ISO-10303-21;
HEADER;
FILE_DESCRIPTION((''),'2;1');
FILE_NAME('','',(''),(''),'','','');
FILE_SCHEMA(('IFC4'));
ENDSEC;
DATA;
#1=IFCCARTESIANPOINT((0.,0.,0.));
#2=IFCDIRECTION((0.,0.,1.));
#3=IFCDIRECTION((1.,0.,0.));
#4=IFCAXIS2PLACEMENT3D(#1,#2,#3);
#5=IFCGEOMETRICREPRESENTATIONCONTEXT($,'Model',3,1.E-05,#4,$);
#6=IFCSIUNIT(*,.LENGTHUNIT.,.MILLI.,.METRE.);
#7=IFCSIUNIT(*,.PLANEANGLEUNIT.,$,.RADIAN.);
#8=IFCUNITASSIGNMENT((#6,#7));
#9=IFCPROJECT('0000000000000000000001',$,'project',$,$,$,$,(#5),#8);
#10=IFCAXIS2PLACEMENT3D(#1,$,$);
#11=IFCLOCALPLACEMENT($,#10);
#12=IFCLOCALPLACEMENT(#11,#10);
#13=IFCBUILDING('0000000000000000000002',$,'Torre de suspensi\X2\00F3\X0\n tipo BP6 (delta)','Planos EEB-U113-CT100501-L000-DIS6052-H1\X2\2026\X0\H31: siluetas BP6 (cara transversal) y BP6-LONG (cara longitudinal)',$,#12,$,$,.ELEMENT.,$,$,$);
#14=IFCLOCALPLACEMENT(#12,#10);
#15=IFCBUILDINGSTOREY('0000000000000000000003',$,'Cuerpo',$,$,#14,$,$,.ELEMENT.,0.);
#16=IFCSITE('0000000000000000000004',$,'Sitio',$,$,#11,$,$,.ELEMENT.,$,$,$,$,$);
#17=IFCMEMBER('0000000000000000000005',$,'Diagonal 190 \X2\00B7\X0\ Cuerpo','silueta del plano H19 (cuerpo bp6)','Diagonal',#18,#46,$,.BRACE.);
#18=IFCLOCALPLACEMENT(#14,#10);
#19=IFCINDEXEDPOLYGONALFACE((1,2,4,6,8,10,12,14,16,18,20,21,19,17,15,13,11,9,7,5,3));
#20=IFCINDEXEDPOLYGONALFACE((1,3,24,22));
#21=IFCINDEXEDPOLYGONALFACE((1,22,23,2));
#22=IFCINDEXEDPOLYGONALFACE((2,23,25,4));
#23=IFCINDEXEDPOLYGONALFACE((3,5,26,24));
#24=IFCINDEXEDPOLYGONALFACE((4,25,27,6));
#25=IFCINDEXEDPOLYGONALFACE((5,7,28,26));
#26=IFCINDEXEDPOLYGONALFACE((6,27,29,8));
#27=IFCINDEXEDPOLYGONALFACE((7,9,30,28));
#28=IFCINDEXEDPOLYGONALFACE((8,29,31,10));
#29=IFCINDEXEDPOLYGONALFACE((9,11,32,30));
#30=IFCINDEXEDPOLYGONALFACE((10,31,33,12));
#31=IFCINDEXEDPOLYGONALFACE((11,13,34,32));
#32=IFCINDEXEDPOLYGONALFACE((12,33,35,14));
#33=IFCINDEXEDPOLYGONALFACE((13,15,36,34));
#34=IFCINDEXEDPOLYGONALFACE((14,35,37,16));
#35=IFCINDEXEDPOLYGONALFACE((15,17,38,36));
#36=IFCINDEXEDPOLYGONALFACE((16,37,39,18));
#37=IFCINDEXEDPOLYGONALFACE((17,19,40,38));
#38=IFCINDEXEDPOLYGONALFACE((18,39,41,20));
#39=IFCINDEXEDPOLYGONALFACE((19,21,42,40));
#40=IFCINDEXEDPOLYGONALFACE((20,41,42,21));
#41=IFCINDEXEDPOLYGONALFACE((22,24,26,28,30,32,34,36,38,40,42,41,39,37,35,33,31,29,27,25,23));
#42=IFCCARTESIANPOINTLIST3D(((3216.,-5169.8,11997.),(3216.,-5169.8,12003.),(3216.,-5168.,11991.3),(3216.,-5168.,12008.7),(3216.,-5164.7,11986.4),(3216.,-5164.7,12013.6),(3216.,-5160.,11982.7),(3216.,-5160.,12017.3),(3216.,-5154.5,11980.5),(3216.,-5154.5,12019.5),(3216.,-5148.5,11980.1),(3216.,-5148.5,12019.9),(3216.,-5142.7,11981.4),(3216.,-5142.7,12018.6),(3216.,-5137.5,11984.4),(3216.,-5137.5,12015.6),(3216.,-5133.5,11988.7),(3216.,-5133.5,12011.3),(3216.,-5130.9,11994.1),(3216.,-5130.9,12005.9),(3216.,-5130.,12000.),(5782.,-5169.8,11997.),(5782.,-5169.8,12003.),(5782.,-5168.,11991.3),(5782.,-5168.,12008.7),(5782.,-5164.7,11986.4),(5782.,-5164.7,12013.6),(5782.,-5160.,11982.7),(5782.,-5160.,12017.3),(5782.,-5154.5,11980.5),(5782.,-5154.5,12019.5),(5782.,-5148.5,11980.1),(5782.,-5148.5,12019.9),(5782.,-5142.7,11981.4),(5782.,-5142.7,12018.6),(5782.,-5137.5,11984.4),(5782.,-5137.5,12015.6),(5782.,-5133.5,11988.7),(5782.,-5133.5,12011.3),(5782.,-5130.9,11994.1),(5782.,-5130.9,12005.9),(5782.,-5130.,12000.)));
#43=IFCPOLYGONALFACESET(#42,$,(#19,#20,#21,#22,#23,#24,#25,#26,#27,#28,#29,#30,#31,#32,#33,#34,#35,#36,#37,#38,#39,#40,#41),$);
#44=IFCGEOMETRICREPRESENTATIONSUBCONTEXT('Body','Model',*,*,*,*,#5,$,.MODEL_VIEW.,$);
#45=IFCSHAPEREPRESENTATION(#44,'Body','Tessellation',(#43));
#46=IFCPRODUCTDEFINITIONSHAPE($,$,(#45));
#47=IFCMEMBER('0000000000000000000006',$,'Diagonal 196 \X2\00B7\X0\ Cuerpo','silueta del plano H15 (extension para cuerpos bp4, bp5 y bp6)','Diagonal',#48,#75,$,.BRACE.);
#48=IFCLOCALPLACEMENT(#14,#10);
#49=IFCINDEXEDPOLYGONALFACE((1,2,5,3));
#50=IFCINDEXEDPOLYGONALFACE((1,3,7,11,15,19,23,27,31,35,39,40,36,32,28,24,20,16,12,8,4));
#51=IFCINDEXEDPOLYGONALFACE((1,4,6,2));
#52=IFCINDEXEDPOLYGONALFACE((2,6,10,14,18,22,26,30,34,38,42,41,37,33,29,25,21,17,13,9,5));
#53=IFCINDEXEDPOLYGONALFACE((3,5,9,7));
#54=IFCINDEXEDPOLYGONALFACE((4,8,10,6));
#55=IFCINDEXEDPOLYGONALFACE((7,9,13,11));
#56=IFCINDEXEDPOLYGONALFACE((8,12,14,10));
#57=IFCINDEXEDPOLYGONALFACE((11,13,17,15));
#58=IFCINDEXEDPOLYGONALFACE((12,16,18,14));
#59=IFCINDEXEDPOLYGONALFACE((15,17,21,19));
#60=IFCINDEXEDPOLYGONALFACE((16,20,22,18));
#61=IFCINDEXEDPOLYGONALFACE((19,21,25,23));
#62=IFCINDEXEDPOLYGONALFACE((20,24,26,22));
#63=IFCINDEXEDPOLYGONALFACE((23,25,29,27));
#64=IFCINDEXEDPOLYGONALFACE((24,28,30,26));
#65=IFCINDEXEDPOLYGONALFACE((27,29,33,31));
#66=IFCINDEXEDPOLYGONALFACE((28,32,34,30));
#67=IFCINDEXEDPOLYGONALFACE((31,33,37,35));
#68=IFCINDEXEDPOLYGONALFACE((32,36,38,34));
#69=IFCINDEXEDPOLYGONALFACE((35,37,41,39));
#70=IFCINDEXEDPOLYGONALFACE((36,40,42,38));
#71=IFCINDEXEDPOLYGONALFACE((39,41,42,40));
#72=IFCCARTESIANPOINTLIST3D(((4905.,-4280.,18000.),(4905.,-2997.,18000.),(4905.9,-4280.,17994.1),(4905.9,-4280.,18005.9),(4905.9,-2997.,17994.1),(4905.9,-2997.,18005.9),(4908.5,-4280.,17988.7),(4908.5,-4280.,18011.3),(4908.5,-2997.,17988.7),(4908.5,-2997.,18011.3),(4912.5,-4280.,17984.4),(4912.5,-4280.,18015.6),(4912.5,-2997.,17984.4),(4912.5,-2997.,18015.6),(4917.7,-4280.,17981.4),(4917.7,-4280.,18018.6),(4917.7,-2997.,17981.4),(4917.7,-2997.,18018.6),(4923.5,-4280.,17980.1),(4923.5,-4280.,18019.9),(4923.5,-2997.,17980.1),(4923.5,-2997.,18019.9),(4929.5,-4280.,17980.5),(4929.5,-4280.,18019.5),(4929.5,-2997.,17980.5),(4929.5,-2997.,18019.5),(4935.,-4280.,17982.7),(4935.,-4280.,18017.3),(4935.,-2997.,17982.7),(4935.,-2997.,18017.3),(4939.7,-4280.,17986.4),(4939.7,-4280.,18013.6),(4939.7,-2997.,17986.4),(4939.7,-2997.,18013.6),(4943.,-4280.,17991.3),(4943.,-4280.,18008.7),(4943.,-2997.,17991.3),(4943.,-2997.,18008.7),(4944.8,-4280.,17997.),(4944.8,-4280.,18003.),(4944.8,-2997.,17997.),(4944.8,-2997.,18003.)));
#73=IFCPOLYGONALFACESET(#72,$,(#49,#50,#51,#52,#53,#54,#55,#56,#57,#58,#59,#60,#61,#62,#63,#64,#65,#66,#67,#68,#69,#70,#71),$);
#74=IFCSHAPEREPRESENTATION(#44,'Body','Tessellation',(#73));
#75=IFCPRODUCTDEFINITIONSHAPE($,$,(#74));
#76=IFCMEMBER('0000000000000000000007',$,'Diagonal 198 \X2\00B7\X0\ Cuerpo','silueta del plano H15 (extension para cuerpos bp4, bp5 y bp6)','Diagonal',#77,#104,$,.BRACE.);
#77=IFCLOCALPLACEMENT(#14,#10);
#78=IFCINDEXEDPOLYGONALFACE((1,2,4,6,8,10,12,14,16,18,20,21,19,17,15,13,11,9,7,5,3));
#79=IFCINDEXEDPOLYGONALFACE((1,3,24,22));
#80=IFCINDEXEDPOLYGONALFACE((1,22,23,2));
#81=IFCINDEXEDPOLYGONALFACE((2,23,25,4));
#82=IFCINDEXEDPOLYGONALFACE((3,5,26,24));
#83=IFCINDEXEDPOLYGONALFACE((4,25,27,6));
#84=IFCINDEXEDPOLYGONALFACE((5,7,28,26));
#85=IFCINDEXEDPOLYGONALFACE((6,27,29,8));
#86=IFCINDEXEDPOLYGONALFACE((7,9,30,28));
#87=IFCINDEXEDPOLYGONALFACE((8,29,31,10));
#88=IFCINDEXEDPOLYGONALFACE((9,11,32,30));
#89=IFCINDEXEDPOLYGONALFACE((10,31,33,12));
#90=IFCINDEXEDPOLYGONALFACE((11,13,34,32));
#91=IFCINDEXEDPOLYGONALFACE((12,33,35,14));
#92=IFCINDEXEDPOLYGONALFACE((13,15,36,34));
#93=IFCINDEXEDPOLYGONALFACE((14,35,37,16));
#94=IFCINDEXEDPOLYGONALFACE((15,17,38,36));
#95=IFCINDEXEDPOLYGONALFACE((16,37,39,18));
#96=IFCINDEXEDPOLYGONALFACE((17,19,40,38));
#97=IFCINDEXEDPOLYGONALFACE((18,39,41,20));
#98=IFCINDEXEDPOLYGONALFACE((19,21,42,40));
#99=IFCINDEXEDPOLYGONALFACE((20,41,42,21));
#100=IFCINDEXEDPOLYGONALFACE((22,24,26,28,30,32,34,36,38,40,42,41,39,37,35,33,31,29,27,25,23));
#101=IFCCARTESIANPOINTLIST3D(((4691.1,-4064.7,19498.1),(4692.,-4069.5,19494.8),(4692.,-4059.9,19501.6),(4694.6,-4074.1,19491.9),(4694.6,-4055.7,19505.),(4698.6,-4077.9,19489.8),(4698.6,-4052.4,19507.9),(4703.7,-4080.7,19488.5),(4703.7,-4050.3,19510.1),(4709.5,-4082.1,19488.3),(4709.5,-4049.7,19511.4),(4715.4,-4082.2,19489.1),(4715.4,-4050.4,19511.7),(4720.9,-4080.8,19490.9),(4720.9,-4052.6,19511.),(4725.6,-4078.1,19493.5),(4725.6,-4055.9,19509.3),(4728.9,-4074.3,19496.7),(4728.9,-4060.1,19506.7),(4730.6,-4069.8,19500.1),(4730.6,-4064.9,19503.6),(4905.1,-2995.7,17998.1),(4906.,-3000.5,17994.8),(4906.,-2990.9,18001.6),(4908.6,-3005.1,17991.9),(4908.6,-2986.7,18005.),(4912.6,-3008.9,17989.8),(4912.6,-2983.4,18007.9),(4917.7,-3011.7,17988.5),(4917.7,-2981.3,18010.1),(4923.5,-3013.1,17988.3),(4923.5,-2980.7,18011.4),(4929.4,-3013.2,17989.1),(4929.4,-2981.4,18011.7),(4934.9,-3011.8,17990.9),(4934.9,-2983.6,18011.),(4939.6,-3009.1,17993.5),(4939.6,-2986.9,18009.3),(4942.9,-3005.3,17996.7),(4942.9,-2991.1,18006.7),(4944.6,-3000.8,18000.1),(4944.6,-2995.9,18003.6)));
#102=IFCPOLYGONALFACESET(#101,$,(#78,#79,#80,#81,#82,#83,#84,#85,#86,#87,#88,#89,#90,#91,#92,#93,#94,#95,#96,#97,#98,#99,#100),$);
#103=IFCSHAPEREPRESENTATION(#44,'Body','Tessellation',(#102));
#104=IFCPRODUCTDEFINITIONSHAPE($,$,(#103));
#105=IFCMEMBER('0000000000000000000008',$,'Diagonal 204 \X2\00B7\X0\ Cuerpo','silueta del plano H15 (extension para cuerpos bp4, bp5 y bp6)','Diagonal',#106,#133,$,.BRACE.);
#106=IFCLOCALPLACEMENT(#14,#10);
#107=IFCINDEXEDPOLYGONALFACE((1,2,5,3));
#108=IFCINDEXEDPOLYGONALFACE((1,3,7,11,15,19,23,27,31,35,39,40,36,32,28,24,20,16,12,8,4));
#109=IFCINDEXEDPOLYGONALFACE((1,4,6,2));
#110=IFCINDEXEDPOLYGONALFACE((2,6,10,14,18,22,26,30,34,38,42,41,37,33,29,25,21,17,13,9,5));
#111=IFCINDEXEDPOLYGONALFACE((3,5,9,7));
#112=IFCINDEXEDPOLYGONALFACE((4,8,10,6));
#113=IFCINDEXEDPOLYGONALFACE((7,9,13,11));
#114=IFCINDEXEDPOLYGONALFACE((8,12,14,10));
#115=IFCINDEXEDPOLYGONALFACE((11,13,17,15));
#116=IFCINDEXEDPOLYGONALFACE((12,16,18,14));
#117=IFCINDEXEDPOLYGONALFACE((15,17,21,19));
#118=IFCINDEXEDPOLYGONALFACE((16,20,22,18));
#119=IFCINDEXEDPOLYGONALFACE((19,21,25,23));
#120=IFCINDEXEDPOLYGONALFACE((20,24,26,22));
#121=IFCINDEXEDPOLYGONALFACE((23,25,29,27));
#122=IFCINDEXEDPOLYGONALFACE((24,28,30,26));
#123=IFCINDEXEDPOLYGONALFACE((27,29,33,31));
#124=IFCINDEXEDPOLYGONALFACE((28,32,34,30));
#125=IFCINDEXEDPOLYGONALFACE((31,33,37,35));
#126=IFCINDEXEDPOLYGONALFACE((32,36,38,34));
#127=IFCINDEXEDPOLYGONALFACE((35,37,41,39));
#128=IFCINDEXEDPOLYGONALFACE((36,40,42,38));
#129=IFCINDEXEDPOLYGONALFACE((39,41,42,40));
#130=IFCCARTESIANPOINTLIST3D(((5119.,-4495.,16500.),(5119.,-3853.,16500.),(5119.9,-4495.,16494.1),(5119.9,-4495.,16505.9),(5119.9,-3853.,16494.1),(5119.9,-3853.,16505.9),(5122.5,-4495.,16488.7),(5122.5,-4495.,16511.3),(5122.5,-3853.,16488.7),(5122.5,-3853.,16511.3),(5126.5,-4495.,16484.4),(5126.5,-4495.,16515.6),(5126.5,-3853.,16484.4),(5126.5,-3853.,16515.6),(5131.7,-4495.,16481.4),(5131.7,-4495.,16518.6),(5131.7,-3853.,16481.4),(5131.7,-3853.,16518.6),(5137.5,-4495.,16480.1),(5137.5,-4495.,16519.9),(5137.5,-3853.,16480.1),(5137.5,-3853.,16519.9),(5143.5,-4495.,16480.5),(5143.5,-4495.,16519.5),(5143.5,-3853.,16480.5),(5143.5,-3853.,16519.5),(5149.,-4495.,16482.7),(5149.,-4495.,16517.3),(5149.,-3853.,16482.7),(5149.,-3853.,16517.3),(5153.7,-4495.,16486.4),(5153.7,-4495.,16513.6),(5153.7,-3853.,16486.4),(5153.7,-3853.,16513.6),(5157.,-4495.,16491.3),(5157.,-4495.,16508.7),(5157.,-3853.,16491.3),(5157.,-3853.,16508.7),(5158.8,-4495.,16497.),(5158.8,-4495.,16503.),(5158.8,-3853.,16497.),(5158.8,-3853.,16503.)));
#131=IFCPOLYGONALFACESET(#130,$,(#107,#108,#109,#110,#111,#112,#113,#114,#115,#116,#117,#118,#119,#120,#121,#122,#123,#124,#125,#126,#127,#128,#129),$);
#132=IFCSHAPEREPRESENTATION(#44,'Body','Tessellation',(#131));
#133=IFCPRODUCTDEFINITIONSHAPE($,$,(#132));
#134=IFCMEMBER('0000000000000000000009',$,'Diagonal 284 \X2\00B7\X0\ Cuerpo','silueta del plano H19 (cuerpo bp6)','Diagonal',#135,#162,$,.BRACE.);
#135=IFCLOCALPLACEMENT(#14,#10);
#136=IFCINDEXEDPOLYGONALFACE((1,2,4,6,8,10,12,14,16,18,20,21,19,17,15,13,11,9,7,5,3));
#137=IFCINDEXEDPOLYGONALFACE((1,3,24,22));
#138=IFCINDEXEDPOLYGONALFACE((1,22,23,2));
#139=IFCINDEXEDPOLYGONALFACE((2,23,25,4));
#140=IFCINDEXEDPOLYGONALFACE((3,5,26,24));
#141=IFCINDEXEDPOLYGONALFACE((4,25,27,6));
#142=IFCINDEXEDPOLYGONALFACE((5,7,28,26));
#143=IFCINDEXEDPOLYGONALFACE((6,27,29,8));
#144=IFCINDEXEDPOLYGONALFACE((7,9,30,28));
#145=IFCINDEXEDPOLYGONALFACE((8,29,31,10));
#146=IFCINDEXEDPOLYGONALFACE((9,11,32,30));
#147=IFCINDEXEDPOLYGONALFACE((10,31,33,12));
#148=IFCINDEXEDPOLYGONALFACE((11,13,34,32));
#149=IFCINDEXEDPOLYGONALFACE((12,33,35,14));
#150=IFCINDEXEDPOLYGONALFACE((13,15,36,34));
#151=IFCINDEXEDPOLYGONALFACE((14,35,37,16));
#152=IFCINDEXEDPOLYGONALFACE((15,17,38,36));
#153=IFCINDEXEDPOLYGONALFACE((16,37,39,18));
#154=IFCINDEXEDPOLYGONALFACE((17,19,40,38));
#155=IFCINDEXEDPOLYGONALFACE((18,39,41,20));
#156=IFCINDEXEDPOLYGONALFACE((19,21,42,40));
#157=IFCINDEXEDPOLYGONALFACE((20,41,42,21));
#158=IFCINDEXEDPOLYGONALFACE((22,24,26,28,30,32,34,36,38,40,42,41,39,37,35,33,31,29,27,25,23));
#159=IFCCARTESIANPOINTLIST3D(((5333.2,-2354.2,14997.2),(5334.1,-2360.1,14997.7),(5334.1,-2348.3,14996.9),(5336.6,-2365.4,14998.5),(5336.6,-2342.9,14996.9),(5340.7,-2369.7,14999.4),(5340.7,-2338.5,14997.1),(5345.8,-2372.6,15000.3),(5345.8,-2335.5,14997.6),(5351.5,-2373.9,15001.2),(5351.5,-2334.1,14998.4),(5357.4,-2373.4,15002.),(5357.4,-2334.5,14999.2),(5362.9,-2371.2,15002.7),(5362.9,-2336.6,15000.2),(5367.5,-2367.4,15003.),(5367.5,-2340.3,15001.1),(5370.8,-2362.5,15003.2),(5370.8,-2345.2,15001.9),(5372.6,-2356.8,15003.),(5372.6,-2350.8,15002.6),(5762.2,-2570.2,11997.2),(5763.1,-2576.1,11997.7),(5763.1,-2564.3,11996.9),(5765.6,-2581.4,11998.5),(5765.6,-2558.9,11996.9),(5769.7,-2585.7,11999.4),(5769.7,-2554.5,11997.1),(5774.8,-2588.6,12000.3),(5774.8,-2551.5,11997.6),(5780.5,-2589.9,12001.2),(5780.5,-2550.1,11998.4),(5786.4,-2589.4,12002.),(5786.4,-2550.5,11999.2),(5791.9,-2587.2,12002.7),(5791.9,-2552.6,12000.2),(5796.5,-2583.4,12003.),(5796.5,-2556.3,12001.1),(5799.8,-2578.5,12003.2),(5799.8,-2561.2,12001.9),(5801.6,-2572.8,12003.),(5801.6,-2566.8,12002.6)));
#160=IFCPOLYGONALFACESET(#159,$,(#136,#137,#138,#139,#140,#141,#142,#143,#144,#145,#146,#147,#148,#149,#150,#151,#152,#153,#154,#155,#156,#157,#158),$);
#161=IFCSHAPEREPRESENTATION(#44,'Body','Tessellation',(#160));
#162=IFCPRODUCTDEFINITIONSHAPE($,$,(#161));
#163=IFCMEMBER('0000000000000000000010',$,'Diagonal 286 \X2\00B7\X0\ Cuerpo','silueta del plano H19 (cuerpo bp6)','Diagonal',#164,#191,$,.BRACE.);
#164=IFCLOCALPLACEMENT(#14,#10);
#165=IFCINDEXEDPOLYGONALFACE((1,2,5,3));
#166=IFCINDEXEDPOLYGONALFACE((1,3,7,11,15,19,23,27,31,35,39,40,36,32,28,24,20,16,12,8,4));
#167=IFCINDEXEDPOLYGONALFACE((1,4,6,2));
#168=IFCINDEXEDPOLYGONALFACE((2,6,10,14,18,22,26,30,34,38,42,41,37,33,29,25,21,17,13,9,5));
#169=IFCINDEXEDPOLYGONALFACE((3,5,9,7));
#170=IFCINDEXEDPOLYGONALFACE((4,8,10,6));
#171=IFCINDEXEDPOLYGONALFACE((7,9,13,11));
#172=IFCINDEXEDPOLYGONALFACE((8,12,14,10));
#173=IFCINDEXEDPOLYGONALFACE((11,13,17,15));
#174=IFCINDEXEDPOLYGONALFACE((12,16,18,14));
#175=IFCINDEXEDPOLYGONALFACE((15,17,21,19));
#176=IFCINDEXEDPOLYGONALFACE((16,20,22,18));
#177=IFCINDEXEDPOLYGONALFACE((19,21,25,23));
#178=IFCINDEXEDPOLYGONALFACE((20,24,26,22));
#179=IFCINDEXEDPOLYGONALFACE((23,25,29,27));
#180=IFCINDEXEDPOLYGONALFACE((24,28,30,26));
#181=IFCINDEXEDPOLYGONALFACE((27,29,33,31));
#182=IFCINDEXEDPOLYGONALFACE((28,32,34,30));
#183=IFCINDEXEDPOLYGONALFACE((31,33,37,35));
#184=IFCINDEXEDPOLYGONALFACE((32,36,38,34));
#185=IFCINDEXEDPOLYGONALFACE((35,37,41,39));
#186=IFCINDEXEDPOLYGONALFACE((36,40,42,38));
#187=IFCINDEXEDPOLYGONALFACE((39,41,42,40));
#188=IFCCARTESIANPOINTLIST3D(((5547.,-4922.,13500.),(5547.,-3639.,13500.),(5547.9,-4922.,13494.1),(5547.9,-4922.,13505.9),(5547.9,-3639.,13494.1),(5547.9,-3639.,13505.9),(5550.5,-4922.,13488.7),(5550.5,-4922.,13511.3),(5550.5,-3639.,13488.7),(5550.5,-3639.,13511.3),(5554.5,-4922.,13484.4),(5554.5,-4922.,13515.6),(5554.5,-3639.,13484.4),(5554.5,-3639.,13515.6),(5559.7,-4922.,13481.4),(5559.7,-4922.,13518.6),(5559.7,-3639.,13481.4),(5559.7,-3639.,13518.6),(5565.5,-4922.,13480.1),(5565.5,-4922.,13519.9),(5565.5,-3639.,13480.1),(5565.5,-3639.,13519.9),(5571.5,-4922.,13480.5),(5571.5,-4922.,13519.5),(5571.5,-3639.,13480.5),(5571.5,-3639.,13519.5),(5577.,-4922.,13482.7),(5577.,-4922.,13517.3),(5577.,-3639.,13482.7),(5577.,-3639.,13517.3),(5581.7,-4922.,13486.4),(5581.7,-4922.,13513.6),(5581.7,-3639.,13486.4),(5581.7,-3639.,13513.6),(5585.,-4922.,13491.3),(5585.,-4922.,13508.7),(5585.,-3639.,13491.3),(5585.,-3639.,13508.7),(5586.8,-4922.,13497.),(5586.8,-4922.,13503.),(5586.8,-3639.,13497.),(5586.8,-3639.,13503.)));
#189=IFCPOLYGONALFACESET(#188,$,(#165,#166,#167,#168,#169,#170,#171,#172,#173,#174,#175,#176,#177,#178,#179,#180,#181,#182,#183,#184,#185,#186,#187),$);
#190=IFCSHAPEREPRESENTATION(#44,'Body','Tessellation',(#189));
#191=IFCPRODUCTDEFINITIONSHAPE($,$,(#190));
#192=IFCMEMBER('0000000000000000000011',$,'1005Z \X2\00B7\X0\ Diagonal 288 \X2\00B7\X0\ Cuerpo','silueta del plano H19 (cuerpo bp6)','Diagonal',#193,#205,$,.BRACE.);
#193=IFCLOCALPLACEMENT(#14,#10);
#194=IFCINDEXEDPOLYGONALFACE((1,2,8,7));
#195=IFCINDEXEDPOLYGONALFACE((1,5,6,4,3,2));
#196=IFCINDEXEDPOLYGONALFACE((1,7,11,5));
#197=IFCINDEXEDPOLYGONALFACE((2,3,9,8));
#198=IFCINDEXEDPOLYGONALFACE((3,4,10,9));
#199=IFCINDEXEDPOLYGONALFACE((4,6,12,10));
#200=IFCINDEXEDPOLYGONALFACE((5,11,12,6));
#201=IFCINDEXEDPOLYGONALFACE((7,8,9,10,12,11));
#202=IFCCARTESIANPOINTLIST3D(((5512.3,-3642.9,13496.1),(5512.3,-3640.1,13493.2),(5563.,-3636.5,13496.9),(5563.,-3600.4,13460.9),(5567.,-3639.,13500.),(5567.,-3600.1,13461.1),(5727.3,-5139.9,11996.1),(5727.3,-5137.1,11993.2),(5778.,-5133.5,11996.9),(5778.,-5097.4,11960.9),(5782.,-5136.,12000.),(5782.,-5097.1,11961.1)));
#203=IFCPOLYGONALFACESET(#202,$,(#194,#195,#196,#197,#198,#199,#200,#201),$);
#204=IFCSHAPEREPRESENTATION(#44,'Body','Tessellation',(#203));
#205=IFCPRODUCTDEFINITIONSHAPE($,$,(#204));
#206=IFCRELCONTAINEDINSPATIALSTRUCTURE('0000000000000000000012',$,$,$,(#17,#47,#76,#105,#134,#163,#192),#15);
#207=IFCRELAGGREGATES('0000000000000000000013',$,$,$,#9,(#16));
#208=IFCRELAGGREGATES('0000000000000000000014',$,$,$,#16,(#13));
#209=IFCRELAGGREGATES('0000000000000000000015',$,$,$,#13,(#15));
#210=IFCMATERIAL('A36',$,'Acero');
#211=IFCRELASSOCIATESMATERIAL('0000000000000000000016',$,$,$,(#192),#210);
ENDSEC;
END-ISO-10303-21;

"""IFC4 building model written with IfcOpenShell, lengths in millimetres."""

from ifc_helpers import new_model, si_unit, frame, frame_2d, origin, origin_with_axes, place, context, subcontext, project, spatial, circle, l_section, extrude, material, element, save


model = new_model("IFC4")

# Units and contexts
model_context = context("Model", 3, precision=1e-05, world=origin_with_axes())
body_context = subcontext(model_context, "Body", "Model", "MODEL_VIEW")
ifc_project = project(units=[si_unit("LENGTHUNIT", "METRE", prefix="MILLI"), si_unit("PLANEANGLEUNIT", "RADIAN")], contexts=[model_context])

# Site, building, storey
site_placement = place(None, origin())
site = spatial("IfcSite", under=ifc_project, at=site_placement, Name="Sitio", CompositionType="ELEMENT")
building_placement = place(site_placement, origin())
building = spatial("IfcBuilding", under=site, at=building_placement, Name="Torre de suspensión tipo BP6 (delta)", Description="Planos EEB-U113-CT100501-L000-DIS6052-H1…H31: siluetas BP6 (cara transversal) y BP6-LONG (cara longitudinal)", CompositionType="ELEMENT")
storey_placement = place(building_placement, origin())
storey = spatial("IfcBuildingStorey", under=building, at=storey_placement, Name="Cuerpo", CompositionType="ELEMENT", Elevation=0.0)

# Members
ifc_material_1 = material(Name="A36", Category="Acero")
member_1_placement = place(storey_placement, frame((5782.0, -5150.0, 12000.0), z_axis=(-1.0, 0.0, 0.0), x_axis=(0.0, 1.0, 0.0)))
element("IfcMember", 1, at=member_1_placement, inside=storey, Name="Diagonal 190 · Cuerpo", Description="silueta del plano H19 (cuerpo bp6)", ObjectType="Diagonal", PredefinedType="BRACE", context=body_context, shape_type="SweptSolid", body=[
    extrude(circle(Radius=20.0), None, (0.0, 0.0, 1.0), 2566.0),
])
member_2_placement = place(storey_placement, frame((4925.0, -2997.0, 18000.0), z_axis=(0.0, -1.0, 0.0), x_axis=(-1.0, 0.0, 0.0)))
element("IfcMember", 2, at=member_2_placement, inside=storey, Name="Diagonal 196 · Cuerpo", Description="silueta del plano H15 (extension para cuerpos bp4, bp5 y bp6)", ObjectType="Diagonal", PredefinedType="BRACE", context=body_context, shape_type="SweptSolid", body=[
    extrude(circle(Radius=20.0), None, (0.0, 0.0, 1.0), 1283.0),
])
member_3_placement = place(storey_placement, frame((4925.0, -2997.0, 18000.0), z_axis=(-0.115405, -0.576487, 0.808915), x_axis=(-0.993318, 0.066977, -0.093981)))
element("IfcMember", 3, at=member_3_placement, inside=storey, Name="Diagonal 198 · Cuerpo", Description="silueta del plano H15 (extension para cuerpos bp4, bp5 y bp6)", ObjectType="Diagonal", PredefinedType="BRACE", context=body_context, shape_type="SweptSolid", body=[
    extrude(circle(Radius=20.0), None, (0.0, 0.0, 1.0), 1854.3),
])
member_4_placement = place(storey_placement, frame((5139.0, -3853.0, 16500.0), z_axis=(0.0, -1.0, 0.0), x_axis=(-1.0, 0.0, 0.0)))
element("IfcMember", 4, at=member_4_placement, inside=storey, Name="Diagonal 204 · Cuerpo", Description="silueta del plano H15 (extension para cuerpos bp4, bp5 y bp6)", ObjectType="Diagonal", PredefinedType="BRACE", context=body_context, shape_type="SweptSolid", body=[
    extrude(circle(Radius=20.0), None, (0.0, 0.0, 1.0), 642.0),
])
member_5_placement = place(storey_placement, frame((5782.0, -2570.0, 12000.0), z_axis=(-0.141202, 0.071095, 0.987425), x_axis=(-0.989981, -0.01014, -0.140837)))
element("IfcMember", 5, at=member_5_placement, inside=storey, Name="Diagonal 284 · Cuerpo", Description="silueta del plano H19 (cuerpo bp6)", ObjectType="Diagonal", PredefinedType="BRACE", context=body_context, shape_type="SweptSolid", body=[
    extrude(circle(Radius=20.0), None, (0.0, 0.0, 1.0), 3038.2),
])
member_6_placement = place(storey_placement, frame((5567.0, -4922.0, 13500.0), z_axis=(0.0, 1.0, 0.0), x_axis=(-1.0, 0.0, 0.0)))
element("IfcMember", 6, at=member_6_placement, inside=storey, Name="Diagonal 286 · Cuerpo", Description="silueta del plano H19 (cuerpo bp6)", ObjectType="Diagonal", PredefinedType="BRACE", context=body_context, shape_type="SweptSolid", body=[
    extrude(circle(Radius=20.0), None, (0.0, 0.0, 1.0), 1283.0),
])
member_7_placement = place(storey_placement, frame((5567.0, -3639.0, 13500.0), z_axis=(0.100935, -0.702791, -0.704199), x_axis=(-0.994893, -0.071301, -0.071443)))
element("IfcMember", 7, at=member_7_placement, inside=storey, material=ifc_material_1, Name="1005Z · Diagonal 288 · Cuerpo", Description="silueta del plano H19 (cuerpo bp6)", ObjectType="Diagonal", PredefinedType="BRACE", context=body_context, shape_type="SweptSolid", body=[
    extrude(l_section(Depth=55.0, Width=55.0, Thickness=4.0, at=frame_2d((27.5, 27.5))), None, (0.0, 0.0, 1.0), 2130.1),
])

save(model, "model.ifc")
